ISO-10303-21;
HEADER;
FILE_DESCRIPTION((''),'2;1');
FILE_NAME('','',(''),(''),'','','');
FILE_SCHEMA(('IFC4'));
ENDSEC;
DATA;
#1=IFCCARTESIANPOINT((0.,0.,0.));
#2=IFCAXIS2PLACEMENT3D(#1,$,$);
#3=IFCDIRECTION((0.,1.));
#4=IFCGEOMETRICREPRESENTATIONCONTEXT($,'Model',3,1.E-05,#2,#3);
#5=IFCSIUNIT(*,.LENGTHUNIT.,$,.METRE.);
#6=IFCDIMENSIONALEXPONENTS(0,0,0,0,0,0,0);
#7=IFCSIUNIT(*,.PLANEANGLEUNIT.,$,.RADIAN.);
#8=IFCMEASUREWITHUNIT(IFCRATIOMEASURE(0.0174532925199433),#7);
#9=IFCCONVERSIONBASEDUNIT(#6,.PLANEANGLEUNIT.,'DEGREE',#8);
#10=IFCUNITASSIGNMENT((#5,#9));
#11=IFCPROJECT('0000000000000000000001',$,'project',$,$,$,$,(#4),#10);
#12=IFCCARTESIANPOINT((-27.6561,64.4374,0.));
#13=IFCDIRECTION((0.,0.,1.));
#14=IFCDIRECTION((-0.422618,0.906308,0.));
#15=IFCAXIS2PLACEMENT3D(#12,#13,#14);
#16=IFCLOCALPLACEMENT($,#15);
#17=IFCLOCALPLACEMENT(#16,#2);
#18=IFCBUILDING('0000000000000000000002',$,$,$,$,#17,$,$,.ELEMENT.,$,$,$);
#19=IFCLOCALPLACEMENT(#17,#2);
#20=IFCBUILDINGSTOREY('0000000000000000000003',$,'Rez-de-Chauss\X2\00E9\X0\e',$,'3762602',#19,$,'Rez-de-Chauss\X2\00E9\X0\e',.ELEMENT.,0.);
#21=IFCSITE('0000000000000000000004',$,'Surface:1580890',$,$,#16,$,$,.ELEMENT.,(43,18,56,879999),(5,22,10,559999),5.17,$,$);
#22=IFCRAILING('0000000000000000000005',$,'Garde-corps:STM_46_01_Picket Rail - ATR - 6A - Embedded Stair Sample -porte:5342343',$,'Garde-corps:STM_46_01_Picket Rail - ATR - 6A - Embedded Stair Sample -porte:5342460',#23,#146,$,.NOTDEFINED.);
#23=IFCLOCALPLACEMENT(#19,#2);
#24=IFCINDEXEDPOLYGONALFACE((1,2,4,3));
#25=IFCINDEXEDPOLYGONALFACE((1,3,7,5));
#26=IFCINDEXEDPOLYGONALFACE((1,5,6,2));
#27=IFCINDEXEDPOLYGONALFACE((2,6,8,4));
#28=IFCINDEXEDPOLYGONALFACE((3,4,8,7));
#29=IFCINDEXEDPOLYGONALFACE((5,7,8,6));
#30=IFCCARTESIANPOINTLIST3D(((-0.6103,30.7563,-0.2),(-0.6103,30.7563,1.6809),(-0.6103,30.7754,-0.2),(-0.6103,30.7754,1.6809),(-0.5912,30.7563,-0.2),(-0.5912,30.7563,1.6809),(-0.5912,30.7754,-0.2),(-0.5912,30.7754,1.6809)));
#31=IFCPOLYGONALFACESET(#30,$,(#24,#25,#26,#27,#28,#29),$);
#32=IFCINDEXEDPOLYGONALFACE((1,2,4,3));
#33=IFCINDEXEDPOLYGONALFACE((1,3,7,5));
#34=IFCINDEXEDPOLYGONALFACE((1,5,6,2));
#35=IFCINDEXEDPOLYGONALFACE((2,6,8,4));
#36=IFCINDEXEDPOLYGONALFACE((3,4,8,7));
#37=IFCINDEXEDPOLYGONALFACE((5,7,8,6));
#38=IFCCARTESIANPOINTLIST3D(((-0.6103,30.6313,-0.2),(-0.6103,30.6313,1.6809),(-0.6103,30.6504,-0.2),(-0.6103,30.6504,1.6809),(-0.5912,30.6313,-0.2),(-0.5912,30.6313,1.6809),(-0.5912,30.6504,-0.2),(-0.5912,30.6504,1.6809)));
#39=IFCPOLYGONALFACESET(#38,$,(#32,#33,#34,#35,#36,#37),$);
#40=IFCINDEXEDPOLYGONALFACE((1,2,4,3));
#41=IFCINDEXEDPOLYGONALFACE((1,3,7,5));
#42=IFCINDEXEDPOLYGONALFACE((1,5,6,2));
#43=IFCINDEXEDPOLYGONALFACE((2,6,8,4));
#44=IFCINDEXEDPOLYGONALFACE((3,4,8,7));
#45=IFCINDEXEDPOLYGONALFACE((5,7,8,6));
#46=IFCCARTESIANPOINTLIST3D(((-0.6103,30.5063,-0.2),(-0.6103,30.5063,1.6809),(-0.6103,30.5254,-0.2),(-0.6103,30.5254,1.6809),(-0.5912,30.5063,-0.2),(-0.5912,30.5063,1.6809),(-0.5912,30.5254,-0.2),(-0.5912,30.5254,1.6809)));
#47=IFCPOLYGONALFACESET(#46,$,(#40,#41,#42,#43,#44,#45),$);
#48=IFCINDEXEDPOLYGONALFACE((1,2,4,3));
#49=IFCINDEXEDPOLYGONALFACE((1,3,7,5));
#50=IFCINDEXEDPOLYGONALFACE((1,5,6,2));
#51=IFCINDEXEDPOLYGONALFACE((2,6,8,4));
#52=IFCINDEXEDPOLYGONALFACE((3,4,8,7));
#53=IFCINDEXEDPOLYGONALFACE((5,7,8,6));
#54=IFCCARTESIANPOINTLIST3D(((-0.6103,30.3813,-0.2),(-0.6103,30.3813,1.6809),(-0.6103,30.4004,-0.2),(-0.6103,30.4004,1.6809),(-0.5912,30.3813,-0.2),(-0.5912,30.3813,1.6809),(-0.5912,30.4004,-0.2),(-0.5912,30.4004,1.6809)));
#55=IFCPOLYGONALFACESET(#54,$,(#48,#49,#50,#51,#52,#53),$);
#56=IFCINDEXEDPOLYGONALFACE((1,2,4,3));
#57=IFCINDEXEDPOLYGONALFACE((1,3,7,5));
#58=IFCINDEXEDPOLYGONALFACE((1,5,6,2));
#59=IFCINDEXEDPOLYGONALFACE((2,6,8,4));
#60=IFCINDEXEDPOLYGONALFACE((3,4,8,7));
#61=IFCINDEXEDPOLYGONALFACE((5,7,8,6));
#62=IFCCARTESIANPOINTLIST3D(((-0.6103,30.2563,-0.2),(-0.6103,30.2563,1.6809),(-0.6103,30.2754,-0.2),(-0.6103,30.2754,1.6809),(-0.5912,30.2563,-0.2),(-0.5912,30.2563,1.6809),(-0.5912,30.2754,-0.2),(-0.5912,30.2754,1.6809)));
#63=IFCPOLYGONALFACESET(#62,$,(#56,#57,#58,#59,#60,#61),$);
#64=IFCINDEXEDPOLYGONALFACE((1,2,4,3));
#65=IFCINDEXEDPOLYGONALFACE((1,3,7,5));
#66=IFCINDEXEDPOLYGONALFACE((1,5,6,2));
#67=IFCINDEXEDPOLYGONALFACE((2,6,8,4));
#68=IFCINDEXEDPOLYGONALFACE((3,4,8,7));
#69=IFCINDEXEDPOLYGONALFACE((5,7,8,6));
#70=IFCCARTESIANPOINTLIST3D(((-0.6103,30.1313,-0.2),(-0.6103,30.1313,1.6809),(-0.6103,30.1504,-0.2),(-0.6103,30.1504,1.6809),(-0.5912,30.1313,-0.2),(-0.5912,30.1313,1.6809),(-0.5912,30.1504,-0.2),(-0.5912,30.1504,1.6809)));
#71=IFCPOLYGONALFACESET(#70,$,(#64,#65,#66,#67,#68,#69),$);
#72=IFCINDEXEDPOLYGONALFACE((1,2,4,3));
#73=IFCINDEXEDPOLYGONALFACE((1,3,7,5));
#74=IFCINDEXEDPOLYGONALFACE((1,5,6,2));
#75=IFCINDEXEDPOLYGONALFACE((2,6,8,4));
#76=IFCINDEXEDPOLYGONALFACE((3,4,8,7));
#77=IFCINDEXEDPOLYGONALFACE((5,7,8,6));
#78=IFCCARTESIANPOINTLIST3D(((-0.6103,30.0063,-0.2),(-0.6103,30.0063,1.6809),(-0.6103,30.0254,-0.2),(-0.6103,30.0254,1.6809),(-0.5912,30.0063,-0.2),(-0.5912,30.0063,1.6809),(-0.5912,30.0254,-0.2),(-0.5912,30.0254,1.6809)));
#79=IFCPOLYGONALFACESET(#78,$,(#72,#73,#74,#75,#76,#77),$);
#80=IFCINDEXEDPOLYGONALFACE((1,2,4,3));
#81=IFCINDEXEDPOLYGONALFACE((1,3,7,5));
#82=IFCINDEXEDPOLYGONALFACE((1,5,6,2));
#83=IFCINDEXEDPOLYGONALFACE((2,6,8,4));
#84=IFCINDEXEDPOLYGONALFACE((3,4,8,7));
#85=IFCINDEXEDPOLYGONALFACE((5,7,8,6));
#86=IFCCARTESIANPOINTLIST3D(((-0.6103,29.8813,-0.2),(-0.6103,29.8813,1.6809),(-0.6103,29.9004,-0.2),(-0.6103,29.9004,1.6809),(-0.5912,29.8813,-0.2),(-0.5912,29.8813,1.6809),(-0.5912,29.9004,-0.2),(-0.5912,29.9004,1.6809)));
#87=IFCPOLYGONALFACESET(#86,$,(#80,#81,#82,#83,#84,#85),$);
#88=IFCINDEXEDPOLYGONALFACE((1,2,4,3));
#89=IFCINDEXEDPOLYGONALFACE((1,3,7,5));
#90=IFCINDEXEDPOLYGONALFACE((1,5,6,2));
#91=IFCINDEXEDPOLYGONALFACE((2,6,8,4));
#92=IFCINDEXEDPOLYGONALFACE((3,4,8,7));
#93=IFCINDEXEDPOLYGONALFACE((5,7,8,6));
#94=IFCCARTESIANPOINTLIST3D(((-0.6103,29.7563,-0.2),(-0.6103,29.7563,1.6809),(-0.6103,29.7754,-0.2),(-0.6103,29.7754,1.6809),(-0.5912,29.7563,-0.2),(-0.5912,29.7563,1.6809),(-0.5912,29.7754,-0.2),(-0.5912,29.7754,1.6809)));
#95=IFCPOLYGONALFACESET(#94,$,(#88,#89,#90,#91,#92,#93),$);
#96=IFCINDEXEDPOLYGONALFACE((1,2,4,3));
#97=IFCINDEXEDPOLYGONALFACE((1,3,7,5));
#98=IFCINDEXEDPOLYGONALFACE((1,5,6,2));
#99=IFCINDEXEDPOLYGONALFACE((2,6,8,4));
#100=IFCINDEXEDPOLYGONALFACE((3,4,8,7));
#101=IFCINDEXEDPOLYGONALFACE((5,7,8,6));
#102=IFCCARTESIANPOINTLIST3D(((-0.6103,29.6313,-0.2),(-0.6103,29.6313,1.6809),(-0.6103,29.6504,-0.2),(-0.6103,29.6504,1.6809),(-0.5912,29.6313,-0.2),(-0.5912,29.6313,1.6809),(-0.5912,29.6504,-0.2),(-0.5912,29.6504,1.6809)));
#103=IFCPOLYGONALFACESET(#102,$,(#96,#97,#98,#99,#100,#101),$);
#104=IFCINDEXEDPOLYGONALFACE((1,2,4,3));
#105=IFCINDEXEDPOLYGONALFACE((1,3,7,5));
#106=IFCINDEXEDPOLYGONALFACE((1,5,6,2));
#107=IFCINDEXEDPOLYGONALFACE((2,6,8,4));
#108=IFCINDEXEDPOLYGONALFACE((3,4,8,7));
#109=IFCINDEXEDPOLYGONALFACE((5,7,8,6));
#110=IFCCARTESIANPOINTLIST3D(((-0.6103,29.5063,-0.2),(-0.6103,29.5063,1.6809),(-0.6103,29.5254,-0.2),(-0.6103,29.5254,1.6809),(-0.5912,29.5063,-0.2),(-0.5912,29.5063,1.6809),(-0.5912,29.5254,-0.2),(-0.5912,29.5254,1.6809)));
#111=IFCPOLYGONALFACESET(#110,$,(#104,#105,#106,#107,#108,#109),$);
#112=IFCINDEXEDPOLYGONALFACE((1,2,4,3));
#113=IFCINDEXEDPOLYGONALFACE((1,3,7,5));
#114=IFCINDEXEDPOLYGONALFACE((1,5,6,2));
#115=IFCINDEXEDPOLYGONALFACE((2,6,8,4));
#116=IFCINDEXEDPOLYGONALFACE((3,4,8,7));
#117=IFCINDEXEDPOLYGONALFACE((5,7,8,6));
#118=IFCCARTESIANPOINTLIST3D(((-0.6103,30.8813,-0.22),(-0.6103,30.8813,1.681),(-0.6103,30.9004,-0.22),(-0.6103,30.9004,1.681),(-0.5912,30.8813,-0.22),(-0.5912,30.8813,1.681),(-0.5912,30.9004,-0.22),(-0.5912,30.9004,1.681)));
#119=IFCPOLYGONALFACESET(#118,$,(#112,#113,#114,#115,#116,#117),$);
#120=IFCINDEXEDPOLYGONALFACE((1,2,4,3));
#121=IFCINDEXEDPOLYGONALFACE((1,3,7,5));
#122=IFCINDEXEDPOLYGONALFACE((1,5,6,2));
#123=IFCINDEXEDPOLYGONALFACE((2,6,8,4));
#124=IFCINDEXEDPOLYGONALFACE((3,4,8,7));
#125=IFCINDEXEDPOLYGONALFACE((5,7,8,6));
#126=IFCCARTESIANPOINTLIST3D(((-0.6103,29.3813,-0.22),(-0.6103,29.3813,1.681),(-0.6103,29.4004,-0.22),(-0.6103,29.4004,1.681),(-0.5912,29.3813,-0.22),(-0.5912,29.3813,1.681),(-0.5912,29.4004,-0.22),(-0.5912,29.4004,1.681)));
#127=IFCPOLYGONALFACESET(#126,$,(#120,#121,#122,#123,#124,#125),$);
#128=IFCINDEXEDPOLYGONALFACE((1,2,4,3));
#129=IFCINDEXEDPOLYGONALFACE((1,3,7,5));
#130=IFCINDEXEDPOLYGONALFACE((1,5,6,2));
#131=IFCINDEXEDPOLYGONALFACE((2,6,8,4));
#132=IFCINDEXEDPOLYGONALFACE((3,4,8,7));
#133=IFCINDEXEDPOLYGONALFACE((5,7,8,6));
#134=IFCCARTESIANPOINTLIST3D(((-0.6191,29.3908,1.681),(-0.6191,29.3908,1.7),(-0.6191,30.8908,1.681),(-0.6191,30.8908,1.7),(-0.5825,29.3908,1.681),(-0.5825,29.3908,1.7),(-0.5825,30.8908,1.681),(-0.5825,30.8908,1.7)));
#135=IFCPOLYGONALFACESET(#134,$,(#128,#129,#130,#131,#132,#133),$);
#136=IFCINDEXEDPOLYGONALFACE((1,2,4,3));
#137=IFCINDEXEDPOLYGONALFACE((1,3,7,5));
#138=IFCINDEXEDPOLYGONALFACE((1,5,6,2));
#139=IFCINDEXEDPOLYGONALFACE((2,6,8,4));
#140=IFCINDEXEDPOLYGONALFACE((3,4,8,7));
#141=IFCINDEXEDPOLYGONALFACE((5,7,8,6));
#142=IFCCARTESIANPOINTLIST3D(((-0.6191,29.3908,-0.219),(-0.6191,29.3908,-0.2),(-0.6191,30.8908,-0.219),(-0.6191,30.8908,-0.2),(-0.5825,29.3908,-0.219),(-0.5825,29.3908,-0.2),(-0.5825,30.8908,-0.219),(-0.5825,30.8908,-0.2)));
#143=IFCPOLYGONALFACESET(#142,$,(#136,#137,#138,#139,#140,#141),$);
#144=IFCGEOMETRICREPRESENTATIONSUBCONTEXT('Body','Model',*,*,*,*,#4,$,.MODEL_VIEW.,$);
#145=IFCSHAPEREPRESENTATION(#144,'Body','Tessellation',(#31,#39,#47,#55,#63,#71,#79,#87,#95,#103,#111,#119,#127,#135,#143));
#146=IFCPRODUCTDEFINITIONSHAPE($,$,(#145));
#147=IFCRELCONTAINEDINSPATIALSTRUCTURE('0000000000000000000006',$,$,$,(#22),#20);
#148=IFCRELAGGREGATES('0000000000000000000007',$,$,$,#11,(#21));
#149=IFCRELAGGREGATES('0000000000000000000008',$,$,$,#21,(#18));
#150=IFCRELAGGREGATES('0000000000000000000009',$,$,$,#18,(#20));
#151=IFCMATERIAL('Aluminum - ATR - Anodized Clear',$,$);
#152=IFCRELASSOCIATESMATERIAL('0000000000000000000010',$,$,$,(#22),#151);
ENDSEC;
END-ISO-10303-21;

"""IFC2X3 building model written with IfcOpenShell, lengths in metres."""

from ifc_helpers import new_model, entity, si_unit, converted_unit, direction, frame, frame_2d, origin, origin_2d_with_axis, place, context, subcontext, project, spatial, rectangle, extrude, material, element, save


model = new_model("IFC2X3")

# Units and contexts
model_context = context("Model", 3, precision=1e-05, world=origin(), true_north=direction((0.0, 1.0)))
body_context = subcontext(model_context, "Body", "Model", "MODEL_VIEW")
ifc_project = project(units=[si_unit("LENGTHUNIT", "METRE"), converted_unit("PLANEANGLEUNIT", "DEGREE", entity("IfcRatioMeasure", 0.0174532925199433), si_unit("PLANEANGLEUNIT", "RADIAN"), dimensions=[0, 0, 0, 0, 0, 0, 0])], contexts=[model_context])

# Site, building, storey
site_placement = place(None, frame((-27.6561, 64.4374, 0.0), z_axis=(0.0, 0.0, 1.0), x_axis=(-0.422618, 0.906308, 0.0)))
site = spatial("IfcSite", under=ifc_project, at=site_placement, Name="Surface:1580890", CompositionType="ELEMENT", RefLatitude=(43, 18, 56, 879999), RefLongitude=(5, 22, 10, 559999), RefElevation=5.17)
building_placement = place(site_placement, origin())
building = spatial("IfcBuilding", under=site, at=building_placement, CompositionType="ELEMENT")
storey_placement = place(building_placement, origin())
storey = spatial("IfcBuildingStorey", under=building, at=storey_placement, Name="Rez-de-Chaussée", ObjectType="3762602", LongName="Rez-de-Chaussée", CompositionType="ELEMENT", Elevation=0.0)

# Railing
ifc_material_1 = material(Name="Aluminum - ATR - Anodized Clear")
railing_1_placement = place(storey_placement, origin())
element("IfcRailing", 1, at=railing_1_placement, inside=storey, material=ifc_material_1, Name="Garde-corps:STM_46_01_Picket Rail - ATR - 6A - Embedded Stair Sample -porte:5342343", ObjectType="Garde-corps:STM_46_01_Picket Rail - ATR - 6A - Embedded Stair Sample -porte:5342460", PredefinedType="NOTDEFINED", context=body_context, shape_type="SweptSolid", body=[
    extrude(rectangle(XDim=0.019, YDim=0.0191, at=frame_2d((0.0, 0.0), x_axis=(1.0, 0.0))), frame((-0.6008, 30.7658, -0.2)), (0.0, 0.0, 1.0), 1.8809),
    extrude(rectangle(XDim=0.019, YDim=0.0191, at=origin_2d_with_axis()), frame((-0.6008, 30.6408, -0.2)), (0.0, 0.0, 1.0), 1.8809),
    extrude(rectangle(XDim=0.019, YDim=0.0191, at=frame_2d((0.0, 0.0), x_axis=(1.0, 0.0))), frame((-0.6008, 30.5158, -0.2)), (0.0, 0.0, 1.0), 1.8809),
    extrude(rectangle(XDim=0.019, YDim=0.0191, at=frame_2d((0.0, 0.0), x_axis=(1.0, 0.0))), frame((-0.6008, 30.3908, -0.2)), (0.0, 0.0, 1.0), 1.8809),
    extrude(rectangle(XDim=0.019, YDim=0.0191, at=frame_2d((0.0, 0.0), x_axis=(1.0, 0.0))), frame((-0.6008, 30.2658, -0.2)), (0.0, 0.0, 1.0), 1.8809),
    extrude(rectangle(XDim=0.019, YDim=0.0191, at=origin_2d_with_axis()), frame((-0.6008, 30.1408, -0.2)), (0.0, 0.0, 1.0), 1.8809),
    extrude(rectangle(XDim=0.019, YDim=0.0191, at=origin_2d_with_axis()), frame((-0.6008, 30.0158, -0.2)), (0.0, 0.0, 1.0), 1.8809),
    extrude(rectangle(XDim=0.019, YDim=0.0191, at=frame_2d((0.0, 0.0), x_axis=(1.0, 0.0))), frame((-0.6008, 29.8908, -0.2)), (0.0, 0.0, 1.0), 1.8809),
    extrude(rectangle(XDim=0.019, YDim=0.0191, at=frame_2d((0.0, 0.0), x_axis=(1.0, 0.0))), frame((-0.6008, 29.7658, -0.2)), (0.0, 0.0, 1.0), 1.8809),
    extrude(rectangle(XDim=0.019, YDim=0.0191, at=origin_2d_with_axis()), frame((-0.6008, 29.6408, -0.2)), (0.0, 0.0, 1.0), 1.8809),
    extrude(rectangle(XDim=0.019, YDim=0.0191, at=frame_2d((0.0, 0.0), x_axis=(1.0, 0.0))), frame((-0.6008, 29.5158, -0.2)), (0.0, 0.0, 1.0), 1.8809),
    extrude(rectangle(XDim=0.019, YDim=0.0191, at=frame_2d((0.0, 0.0), x_axis=(1.0, 0.0))), frame((-0.6008, 30.8908, -0.22)), (0.0, 0.0, 1.0), 1.9009),
    extrude(rectangle(XDim=0.019, YDim=0.0191, at=frame_2d((0.0, 0.0), x_axis=(1.0, 0.0))), frame((-0.6008, 29.3908, -0.22)), (0.0, 0.0, 1.0), 1.9009),
    extrude(rectangle(XDim=1.5, YDim=0.0366, at=frame_2d((0.0, 0.0), x_axis=(1.0, 0.0))), frame((-0.6008, 30.1408, 1.6809), z_axis=(0.0, 0.0, 1.0), x_axis=(0.0, 1.0, 0.0)), (0.0, 0.0, 1.0), 0.0191),
    extrude(rectangle(XDim=1.5, YDim=0.0366, at=frame_2d((0.0, 0.0), x_axis=(1.0, 0.0))), frame((-0.6008, 30.1408, -0.219), z_axis=(0.0, 0.0, 1.0), x_axis=(0.0, 1.0, 0.0)), (0.0, 0.0, 1.0), 0.0191),
])

save(model, "model.ifc")
